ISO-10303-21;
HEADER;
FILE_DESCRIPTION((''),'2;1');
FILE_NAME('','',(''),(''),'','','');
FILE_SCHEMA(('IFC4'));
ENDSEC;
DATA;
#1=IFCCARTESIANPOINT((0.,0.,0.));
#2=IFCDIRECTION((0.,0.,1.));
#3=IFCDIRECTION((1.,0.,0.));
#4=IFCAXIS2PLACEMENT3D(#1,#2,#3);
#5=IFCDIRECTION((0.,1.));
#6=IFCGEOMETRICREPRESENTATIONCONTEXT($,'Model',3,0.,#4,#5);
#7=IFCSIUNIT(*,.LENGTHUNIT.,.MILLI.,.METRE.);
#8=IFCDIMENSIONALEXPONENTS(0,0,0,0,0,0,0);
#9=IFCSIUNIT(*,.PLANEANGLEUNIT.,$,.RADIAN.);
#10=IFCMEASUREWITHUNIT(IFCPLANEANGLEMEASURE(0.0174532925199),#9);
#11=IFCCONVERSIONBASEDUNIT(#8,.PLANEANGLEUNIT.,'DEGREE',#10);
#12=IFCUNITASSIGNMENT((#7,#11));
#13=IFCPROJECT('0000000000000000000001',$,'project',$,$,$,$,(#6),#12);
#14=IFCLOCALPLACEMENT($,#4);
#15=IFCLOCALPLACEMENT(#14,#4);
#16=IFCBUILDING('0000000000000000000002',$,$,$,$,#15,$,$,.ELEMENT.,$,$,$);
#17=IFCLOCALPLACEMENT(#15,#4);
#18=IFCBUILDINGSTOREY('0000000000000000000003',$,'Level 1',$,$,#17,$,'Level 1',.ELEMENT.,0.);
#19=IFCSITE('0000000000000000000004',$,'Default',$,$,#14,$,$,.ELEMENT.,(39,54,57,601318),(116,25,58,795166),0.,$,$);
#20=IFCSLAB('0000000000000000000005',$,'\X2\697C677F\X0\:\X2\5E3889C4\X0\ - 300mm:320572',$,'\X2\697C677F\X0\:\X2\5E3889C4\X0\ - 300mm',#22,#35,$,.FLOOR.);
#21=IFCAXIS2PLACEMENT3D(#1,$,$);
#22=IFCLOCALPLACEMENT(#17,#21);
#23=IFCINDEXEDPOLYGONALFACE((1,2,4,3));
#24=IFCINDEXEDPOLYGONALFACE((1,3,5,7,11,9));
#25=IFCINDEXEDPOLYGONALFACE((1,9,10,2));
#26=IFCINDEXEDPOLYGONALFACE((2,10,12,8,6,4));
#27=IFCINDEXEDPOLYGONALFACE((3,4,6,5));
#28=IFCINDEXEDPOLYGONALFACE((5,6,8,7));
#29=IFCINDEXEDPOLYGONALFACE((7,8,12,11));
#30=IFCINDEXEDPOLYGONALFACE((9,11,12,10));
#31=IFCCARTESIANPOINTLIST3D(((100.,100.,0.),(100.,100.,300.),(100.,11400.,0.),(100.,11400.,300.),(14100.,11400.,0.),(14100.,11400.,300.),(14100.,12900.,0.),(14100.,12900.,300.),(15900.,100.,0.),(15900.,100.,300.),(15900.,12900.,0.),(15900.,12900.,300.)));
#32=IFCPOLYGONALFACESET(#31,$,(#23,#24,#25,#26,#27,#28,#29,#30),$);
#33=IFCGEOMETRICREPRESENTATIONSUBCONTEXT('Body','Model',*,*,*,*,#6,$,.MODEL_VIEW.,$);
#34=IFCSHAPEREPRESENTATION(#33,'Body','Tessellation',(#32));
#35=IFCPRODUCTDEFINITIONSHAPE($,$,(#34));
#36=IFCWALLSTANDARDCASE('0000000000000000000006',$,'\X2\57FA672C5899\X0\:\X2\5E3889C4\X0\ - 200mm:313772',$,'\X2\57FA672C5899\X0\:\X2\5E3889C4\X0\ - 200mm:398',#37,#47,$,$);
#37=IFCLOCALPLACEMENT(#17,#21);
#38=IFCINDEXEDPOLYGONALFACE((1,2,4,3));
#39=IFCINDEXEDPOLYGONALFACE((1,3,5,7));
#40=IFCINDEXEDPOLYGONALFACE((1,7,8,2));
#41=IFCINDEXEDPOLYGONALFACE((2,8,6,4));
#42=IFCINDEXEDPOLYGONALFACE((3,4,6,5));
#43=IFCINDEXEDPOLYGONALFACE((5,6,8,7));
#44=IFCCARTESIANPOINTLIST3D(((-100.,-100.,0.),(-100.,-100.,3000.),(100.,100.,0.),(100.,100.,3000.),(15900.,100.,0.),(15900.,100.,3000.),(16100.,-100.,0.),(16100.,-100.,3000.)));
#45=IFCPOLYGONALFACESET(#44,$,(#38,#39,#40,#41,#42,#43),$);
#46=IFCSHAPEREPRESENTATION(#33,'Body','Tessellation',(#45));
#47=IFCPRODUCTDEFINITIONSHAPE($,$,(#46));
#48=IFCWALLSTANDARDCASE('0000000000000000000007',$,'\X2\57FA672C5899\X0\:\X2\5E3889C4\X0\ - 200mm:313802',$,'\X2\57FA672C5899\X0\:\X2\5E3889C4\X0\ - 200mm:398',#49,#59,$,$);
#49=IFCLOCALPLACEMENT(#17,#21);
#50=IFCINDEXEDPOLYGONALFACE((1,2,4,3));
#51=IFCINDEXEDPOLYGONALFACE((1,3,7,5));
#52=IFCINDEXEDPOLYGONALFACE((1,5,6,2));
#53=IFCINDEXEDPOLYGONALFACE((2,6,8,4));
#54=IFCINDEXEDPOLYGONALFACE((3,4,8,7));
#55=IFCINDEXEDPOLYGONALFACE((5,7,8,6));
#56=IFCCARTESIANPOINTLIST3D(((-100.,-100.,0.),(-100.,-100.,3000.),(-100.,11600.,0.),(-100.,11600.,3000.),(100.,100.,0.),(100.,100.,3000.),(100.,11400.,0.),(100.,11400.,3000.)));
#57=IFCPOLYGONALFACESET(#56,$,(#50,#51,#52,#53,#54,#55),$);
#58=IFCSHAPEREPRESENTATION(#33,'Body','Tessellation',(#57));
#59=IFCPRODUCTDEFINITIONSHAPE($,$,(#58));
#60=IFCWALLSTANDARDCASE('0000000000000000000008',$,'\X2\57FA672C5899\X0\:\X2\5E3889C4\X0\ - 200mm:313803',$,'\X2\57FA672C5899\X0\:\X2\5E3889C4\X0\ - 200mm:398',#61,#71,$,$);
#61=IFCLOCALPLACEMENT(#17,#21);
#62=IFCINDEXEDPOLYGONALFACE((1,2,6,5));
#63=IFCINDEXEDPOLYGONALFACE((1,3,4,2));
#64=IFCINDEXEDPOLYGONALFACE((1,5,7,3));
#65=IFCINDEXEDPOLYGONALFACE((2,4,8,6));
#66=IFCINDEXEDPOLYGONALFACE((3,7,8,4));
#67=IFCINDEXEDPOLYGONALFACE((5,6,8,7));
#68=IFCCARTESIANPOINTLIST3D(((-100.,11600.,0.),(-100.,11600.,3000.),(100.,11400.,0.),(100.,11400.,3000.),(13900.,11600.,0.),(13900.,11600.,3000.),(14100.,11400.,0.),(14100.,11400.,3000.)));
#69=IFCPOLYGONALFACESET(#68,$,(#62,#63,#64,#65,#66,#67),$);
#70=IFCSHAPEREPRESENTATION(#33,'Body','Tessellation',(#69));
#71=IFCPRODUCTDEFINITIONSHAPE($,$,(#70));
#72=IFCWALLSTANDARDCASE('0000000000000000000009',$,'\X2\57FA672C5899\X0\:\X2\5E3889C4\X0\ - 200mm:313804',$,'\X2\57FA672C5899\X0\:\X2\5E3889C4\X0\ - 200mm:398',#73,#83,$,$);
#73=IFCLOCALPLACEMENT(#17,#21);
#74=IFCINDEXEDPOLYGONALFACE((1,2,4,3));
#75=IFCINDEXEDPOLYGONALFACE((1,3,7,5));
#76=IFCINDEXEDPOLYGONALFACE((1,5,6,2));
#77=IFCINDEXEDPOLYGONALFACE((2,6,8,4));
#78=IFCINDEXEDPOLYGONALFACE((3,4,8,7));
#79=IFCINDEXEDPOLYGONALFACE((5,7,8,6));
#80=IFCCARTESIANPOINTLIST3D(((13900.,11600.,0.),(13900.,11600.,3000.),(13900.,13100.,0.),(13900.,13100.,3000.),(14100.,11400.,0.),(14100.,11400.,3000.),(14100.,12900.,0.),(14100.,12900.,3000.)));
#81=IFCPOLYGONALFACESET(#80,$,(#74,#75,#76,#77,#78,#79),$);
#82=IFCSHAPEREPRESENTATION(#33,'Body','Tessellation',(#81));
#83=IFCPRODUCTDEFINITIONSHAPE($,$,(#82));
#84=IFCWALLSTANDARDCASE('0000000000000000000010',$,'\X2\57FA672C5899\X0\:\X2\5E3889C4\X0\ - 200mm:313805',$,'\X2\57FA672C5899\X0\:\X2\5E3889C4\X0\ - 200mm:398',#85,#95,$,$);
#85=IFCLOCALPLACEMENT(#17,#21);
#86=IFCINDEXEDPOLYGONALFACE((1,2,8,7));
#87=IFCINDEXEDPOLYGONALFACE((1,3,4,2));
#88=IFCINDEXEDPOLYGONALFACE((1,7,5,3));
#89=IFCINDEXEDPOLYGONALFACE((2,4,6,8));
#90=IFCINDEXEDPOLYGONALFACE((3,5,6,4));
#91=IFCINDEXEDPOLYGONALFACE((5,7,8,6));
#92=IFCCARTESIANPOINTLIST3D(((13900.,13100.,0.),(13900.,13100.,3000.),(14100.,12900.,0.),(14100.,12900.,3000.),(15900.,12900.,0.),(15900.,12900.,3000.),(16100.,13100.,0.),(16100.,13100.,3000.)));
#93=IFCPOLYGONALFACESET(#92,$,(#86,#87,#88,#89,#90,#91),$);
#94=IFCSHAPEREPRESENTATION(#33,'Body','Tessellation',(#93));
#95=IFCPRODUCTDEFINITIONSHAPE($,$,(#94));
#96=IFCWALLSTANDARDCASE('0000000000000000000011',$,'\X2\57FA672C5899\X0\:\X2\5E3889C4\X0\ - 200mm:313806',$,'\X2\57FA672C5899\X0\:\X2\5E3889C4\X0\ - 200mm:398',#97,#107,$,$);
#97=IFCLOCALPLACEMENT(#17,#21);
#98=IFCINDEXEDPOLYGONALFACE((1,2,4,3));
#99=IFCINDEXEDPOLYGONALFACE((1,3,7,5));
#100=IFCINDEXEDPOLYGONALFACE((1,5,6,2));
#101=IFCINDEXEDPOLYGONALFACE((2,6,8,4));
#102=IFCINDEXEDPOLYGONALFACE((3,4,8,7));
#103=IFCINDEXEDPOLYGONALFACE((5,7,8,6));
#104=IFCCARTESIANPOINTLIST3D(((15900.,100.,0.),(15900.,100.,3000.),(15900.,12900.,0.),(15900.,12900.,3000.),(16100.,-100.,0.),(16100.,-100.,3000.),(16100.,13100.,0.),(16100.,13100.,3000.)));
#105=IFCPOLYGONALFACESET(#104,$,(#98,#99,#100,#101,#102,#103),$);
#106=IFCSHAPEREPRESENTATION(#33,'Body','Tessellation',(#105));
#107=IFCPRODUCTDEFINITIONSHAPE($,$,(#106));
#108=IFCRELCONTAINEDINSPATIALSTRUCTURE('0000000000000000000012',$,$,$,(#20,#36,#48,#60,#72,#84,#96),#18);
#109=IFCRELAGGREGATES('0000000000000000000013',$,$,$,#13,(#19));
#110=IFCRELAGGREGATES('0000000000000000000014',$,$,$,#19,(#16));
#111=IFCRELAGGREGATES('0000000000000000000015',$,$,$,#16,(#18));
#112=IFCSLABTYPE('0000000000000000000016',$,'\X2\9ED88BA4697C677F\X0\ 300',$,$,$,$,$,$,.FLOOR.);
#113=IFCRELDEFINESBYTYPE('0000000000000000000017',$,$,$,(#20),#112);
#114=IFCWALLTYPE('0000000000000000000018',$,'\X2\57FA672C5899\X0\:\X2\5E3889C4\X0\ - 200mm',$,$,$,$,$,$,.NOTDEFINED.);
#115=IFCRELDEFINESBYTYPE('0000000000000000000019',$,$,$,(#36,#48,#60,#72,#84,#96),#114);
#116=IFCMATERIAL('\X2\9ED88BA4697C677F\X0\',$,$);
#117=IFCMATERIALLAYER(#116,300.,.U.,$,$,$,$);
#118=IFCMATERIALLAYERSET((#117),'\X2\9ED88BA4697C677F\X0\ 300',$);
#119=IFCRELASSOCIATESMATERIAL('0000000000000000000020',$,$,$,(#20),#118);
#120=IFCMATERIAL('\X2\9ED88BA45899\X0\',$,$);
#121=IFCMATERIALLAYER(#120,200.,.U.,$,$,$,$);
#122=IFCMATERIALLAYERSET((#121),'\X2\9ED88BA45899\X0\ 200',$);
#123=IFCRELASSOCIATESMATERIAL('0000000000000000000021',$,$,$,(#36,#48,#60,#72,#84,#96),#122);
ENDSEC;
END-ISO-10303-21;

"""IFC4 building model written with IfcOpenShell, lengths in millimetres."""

from ifc_helpers import new_model, entity, si_unit, converted_unit, direction, frame, origin_with_axes, place, context, subcontext, project, spatial, polyline, outline, extrude, material, layer, layer_set, layer_usage, type_object, element, save


model = new_model("IFC4")

# Units and contexts
model_context = context("Model", 3, precision=0.0, world=origin_with_axes(), true_north=direction((0.0, 1.0)))
body_context = subcontext(model_context, "Body", "Model", "MODEL_VIEW")
ifc_project = project(units=[si_unit("LENGTHUNIT", "METRE", prefix="MILLI"), converted_unit("PLANEANGLEUNIT", "DEGREE", entity("IfcPlaneAngleMeasure", 0.0174532925199), si_unit("PLANEANGLEUNIT", "RADIAN"), dimensions=[0, 0, 0, 0, 0, 0, 0])], contexts=[model_context])

# Site, building, storey
site_placement = place(None, origin_with_axes())
site = spatial("IfcSite", under=ifc_project, at=site_placement, Name="Default", CompositionType="ELEMENT", RefLatitude=(39, 54, 57, 601318), RefLongitude=(116, 25, 58, 795166), RefElevation=0.0)
building_placement = place(site_placement, origin_with_axes())
building = spatial("IfcBuilding", under=site, at=building_placement, CompositionType="ELEMENT")
storey_placement = place(building_placement, origin_with_axes())
storey = spatial("IfcBuildingStorey", under=building, at=storey_placement, Name="Level 1", LongName="Level 1", CompositionType="ELEMENT", Elevation=0.0)

# Slab
ifc_material_1 = material(Name="默认楼板")
ifc_layer_1 = layer(ifc_material_1, 300.0, ventilated="UNKNOWN")
ifc_layer_set_1 = layer_set([ifc_layer_1], Name="默认楼板 300")
ifc_layer_usage_1 = layer_usage(ifc_layer_set_1, "AXIS3", "NEGATIVE", 300.0)
slab_type = type_object("IfcSlabType", Name="默认楼板 300", PredefinedType="FLOOR")
slab_placement = place(storey_placement, frame((100.0, 100.0, 0.0), z_axis=(0.0, 0.0, 1.0), x_axis=(1.0, 0.0, 0.0)))
element("IfcSlab", 1, at=slab_placement, inside=storey, type_object=slab_type, material=ifc_layer_usage_1, Name="楼板:常规 - 300mm:320572", ObjectType="楼板:常规 - 300mm", PredefinedType="FLOOR", context=body_context, shape_type="SweptSolid", body=[
    extrude(outline(polyline([(0.0, 0.0), (15800.0, 0.0), (15800.0, 12800.0), (14000.0, 12800.0), (14000.0, 11300.0), (0.0, 11300.0), (0.0, 0.0)])), origin_with_axes(), (0.0, 0.0, 1.0), 300.0),
])

# Walls
ifc_material_2 = material(Name="默认墙")
ifc_layer_2 = layer(ifc_material_2, 200.0, ventilated="UNKNOWN")
ifc_layer_set_2 = layer_set([ifc_layer_2], Name="默认墙 200")
ifc_layer_usage_2 = layer_usage(ifc_layer_set_2, "AXIS2", "POSITIVE", -100.0)
wall_type = type_object("IfcWallType", Name="基本墙:常规 - 200mm", PredefinedType="NOTDEFINED")
wall_1_placement = place(storey_placement, frame((16000.0, 0.0, 0.0), z_axis=(0.0, 0.0, 1.0), x_axis=(-1.0, 0.0, 0.0)))
element("IfcWallStandardCase", 2, at=wall_1_placement, inside=storey, type_object=wall_type, material=ifc_layer_usage_2, Name="基本墙:常规 - 200mm:313772", ObjectType="基本墙:常规 - 200mm:398", context=body_context, shape_type="SweptSolid", body=[
    extrude(outline(polyline([(100.0, -100.0), (15900.0, -100.0), (16100.0, 100.0), (-100.0, 100.0), (100.0, -100.0)])), origin_with_axes(), (0.0, 0.0, 1.0), 3000.0),
])
ifc_layer_usage_3 = layer_usage(ifc_layer_set_2, "AXIS2", "POSITIVE", -100.0)
wall_2_placement = place(storey_placement, frame((0.0, 0.0, 0.0), z_axis=(0.0, 0.0, 1.0), x_axis=(0.0, 1.0, 0.0)))
element("IfcWallStandardCase", 3, at=wall_2_placement, inside=storey, type_object=wall_type, material=ifc_layer_usage_3, Name="基本墙:常规 - 200mm:313802", ObjectType="基本墙:常规 - 200mm:398", context=body_context, shape_type="SweptSolid", body=[
    extrude(outline(polyline([(100.0, -100.0), (11400.0, -100.0), (11600.0, 100.0), (-100.0, 100.0), (100.0, -100.0)])), origin_with_axes(), (0.0, 0.0, 1.0), 3000.0),
])
ifc_layer_usage_4 = layer_usage(ifc_layer_set_2, "AXIS2", "POSITIVE", -100.0)
wall_3_placement = place(storey_placement, frame((0.0, 11500.0, 0.0), z_axis=(0.0, 0.0, 1.0), x_axis=(1.0, 0.0, 0.0)))
element("IfcWallStandardCase", 4, at=wall_3_placement, inside=storey, type_object=wall_type, material=ifc_layer_usage_4, Name="基本墙:常规 - 200mm:313803", ObjectType="基本墙:常规 - 200mm:398", context=body_context, shape_type="SweptSolid", body=[
    extrude(outline(polyline([(100.0, -100.0), (14100.0, -100.0), (13900.0, 100.0), (-100.0, 100.0), (100.0, -100.0)])), origin_with_axes(), (0.0, 0.0, 1.0), 3000.0),
])
ifc_layer_usage_5 = layer_usage(ifc_layer_set_2, "AXIS2", "POSITIVE", -100.0)
wall_4_placement = place(storey_placement, frame((14000.0, 11500.0, 0.0), z_axis=(0.0, 0.0, 1.0), x_axis=(0.0, 1.0, 0.0)))
element("IfcWallStandardCase", 5, at=wall_4_placement, inside=storey, type_object=wall_type, material=ifc_layer_usage_5, Name="基本墙:常规 - 200mm:313804", ObjectType="基本墙:常规 - 200mm:398", context=body_context, shape_type="SweptSolid", body=[
    extrude(outline(polyline([(-100.0, -100.0), (1400.0, -100.0), (1600.0, 100.0), (100.0, 100.0), (-100.0, -100.0)])), origin_with_axes(), (0.0, 0.0, 1.0), 3000.0),
])
ifc_layer_usage_6 = layer_usage(ifc_layer_set_2, "AXIS2", "POSITIVE", -100.0)
wall_5_placement = place(storey_placement, frame((14000.0, 13000.0, 0.0), z_axis=(0.0, 0.0, 1.0), x_axis=(1.0, 0.0, 0.0)))
element("IfcWallStandardCase", 6, at=wall_5_placement, inside=storey, type_object=wall_type, material=ifc_layer_usage_6, Name="基本墙:常规 - 200mm:313805", ObjectType="基本墙:常规 - 200mm:398", context=body_context, shape_type="SweptSolid", body=[
    extrude(outline(polyline([(100.0, -100.0), (1900.0, -100.0), (2100.0, 100.0), (-100.0, 100.0), (100.0, -100.0)])), origin_with_axes(), (0.0, 0.0, 1.0), 3000.0),
])
ifc_layer_usage_7 = layer_usage(ifc_layer_set_2, "AXIS2", "POSITIVE", -100.0)
wall_6_placement = place(storey_placement, frame((16000.0, 13000.0, 0.0), z_axis=(0.0, 0.0, 1.0), x_axis=(0.0, -1.0, 0.0)))
element("IfcWallStandardCase", 7, at=wall_6_placement, inside=storey, type_object=wall_type, material=ifc_layer_usage_7, Name="基本墙:常规 - 200mm:313806", ObjectType="基本墙:常规 - 200mm:398", context=body_context, shape_type="SweptSolid", body=[
    extrude(outline(polyline([(100.0, -100.0), (12900.0, -100.0), (13100.0, 100.0), (-100.0, 100.0), (100.0, -100.0)])), origin_with_axes(), (0.0, 0.0, 1.0), 3000.0),
])

save(model, "model.ifc")
